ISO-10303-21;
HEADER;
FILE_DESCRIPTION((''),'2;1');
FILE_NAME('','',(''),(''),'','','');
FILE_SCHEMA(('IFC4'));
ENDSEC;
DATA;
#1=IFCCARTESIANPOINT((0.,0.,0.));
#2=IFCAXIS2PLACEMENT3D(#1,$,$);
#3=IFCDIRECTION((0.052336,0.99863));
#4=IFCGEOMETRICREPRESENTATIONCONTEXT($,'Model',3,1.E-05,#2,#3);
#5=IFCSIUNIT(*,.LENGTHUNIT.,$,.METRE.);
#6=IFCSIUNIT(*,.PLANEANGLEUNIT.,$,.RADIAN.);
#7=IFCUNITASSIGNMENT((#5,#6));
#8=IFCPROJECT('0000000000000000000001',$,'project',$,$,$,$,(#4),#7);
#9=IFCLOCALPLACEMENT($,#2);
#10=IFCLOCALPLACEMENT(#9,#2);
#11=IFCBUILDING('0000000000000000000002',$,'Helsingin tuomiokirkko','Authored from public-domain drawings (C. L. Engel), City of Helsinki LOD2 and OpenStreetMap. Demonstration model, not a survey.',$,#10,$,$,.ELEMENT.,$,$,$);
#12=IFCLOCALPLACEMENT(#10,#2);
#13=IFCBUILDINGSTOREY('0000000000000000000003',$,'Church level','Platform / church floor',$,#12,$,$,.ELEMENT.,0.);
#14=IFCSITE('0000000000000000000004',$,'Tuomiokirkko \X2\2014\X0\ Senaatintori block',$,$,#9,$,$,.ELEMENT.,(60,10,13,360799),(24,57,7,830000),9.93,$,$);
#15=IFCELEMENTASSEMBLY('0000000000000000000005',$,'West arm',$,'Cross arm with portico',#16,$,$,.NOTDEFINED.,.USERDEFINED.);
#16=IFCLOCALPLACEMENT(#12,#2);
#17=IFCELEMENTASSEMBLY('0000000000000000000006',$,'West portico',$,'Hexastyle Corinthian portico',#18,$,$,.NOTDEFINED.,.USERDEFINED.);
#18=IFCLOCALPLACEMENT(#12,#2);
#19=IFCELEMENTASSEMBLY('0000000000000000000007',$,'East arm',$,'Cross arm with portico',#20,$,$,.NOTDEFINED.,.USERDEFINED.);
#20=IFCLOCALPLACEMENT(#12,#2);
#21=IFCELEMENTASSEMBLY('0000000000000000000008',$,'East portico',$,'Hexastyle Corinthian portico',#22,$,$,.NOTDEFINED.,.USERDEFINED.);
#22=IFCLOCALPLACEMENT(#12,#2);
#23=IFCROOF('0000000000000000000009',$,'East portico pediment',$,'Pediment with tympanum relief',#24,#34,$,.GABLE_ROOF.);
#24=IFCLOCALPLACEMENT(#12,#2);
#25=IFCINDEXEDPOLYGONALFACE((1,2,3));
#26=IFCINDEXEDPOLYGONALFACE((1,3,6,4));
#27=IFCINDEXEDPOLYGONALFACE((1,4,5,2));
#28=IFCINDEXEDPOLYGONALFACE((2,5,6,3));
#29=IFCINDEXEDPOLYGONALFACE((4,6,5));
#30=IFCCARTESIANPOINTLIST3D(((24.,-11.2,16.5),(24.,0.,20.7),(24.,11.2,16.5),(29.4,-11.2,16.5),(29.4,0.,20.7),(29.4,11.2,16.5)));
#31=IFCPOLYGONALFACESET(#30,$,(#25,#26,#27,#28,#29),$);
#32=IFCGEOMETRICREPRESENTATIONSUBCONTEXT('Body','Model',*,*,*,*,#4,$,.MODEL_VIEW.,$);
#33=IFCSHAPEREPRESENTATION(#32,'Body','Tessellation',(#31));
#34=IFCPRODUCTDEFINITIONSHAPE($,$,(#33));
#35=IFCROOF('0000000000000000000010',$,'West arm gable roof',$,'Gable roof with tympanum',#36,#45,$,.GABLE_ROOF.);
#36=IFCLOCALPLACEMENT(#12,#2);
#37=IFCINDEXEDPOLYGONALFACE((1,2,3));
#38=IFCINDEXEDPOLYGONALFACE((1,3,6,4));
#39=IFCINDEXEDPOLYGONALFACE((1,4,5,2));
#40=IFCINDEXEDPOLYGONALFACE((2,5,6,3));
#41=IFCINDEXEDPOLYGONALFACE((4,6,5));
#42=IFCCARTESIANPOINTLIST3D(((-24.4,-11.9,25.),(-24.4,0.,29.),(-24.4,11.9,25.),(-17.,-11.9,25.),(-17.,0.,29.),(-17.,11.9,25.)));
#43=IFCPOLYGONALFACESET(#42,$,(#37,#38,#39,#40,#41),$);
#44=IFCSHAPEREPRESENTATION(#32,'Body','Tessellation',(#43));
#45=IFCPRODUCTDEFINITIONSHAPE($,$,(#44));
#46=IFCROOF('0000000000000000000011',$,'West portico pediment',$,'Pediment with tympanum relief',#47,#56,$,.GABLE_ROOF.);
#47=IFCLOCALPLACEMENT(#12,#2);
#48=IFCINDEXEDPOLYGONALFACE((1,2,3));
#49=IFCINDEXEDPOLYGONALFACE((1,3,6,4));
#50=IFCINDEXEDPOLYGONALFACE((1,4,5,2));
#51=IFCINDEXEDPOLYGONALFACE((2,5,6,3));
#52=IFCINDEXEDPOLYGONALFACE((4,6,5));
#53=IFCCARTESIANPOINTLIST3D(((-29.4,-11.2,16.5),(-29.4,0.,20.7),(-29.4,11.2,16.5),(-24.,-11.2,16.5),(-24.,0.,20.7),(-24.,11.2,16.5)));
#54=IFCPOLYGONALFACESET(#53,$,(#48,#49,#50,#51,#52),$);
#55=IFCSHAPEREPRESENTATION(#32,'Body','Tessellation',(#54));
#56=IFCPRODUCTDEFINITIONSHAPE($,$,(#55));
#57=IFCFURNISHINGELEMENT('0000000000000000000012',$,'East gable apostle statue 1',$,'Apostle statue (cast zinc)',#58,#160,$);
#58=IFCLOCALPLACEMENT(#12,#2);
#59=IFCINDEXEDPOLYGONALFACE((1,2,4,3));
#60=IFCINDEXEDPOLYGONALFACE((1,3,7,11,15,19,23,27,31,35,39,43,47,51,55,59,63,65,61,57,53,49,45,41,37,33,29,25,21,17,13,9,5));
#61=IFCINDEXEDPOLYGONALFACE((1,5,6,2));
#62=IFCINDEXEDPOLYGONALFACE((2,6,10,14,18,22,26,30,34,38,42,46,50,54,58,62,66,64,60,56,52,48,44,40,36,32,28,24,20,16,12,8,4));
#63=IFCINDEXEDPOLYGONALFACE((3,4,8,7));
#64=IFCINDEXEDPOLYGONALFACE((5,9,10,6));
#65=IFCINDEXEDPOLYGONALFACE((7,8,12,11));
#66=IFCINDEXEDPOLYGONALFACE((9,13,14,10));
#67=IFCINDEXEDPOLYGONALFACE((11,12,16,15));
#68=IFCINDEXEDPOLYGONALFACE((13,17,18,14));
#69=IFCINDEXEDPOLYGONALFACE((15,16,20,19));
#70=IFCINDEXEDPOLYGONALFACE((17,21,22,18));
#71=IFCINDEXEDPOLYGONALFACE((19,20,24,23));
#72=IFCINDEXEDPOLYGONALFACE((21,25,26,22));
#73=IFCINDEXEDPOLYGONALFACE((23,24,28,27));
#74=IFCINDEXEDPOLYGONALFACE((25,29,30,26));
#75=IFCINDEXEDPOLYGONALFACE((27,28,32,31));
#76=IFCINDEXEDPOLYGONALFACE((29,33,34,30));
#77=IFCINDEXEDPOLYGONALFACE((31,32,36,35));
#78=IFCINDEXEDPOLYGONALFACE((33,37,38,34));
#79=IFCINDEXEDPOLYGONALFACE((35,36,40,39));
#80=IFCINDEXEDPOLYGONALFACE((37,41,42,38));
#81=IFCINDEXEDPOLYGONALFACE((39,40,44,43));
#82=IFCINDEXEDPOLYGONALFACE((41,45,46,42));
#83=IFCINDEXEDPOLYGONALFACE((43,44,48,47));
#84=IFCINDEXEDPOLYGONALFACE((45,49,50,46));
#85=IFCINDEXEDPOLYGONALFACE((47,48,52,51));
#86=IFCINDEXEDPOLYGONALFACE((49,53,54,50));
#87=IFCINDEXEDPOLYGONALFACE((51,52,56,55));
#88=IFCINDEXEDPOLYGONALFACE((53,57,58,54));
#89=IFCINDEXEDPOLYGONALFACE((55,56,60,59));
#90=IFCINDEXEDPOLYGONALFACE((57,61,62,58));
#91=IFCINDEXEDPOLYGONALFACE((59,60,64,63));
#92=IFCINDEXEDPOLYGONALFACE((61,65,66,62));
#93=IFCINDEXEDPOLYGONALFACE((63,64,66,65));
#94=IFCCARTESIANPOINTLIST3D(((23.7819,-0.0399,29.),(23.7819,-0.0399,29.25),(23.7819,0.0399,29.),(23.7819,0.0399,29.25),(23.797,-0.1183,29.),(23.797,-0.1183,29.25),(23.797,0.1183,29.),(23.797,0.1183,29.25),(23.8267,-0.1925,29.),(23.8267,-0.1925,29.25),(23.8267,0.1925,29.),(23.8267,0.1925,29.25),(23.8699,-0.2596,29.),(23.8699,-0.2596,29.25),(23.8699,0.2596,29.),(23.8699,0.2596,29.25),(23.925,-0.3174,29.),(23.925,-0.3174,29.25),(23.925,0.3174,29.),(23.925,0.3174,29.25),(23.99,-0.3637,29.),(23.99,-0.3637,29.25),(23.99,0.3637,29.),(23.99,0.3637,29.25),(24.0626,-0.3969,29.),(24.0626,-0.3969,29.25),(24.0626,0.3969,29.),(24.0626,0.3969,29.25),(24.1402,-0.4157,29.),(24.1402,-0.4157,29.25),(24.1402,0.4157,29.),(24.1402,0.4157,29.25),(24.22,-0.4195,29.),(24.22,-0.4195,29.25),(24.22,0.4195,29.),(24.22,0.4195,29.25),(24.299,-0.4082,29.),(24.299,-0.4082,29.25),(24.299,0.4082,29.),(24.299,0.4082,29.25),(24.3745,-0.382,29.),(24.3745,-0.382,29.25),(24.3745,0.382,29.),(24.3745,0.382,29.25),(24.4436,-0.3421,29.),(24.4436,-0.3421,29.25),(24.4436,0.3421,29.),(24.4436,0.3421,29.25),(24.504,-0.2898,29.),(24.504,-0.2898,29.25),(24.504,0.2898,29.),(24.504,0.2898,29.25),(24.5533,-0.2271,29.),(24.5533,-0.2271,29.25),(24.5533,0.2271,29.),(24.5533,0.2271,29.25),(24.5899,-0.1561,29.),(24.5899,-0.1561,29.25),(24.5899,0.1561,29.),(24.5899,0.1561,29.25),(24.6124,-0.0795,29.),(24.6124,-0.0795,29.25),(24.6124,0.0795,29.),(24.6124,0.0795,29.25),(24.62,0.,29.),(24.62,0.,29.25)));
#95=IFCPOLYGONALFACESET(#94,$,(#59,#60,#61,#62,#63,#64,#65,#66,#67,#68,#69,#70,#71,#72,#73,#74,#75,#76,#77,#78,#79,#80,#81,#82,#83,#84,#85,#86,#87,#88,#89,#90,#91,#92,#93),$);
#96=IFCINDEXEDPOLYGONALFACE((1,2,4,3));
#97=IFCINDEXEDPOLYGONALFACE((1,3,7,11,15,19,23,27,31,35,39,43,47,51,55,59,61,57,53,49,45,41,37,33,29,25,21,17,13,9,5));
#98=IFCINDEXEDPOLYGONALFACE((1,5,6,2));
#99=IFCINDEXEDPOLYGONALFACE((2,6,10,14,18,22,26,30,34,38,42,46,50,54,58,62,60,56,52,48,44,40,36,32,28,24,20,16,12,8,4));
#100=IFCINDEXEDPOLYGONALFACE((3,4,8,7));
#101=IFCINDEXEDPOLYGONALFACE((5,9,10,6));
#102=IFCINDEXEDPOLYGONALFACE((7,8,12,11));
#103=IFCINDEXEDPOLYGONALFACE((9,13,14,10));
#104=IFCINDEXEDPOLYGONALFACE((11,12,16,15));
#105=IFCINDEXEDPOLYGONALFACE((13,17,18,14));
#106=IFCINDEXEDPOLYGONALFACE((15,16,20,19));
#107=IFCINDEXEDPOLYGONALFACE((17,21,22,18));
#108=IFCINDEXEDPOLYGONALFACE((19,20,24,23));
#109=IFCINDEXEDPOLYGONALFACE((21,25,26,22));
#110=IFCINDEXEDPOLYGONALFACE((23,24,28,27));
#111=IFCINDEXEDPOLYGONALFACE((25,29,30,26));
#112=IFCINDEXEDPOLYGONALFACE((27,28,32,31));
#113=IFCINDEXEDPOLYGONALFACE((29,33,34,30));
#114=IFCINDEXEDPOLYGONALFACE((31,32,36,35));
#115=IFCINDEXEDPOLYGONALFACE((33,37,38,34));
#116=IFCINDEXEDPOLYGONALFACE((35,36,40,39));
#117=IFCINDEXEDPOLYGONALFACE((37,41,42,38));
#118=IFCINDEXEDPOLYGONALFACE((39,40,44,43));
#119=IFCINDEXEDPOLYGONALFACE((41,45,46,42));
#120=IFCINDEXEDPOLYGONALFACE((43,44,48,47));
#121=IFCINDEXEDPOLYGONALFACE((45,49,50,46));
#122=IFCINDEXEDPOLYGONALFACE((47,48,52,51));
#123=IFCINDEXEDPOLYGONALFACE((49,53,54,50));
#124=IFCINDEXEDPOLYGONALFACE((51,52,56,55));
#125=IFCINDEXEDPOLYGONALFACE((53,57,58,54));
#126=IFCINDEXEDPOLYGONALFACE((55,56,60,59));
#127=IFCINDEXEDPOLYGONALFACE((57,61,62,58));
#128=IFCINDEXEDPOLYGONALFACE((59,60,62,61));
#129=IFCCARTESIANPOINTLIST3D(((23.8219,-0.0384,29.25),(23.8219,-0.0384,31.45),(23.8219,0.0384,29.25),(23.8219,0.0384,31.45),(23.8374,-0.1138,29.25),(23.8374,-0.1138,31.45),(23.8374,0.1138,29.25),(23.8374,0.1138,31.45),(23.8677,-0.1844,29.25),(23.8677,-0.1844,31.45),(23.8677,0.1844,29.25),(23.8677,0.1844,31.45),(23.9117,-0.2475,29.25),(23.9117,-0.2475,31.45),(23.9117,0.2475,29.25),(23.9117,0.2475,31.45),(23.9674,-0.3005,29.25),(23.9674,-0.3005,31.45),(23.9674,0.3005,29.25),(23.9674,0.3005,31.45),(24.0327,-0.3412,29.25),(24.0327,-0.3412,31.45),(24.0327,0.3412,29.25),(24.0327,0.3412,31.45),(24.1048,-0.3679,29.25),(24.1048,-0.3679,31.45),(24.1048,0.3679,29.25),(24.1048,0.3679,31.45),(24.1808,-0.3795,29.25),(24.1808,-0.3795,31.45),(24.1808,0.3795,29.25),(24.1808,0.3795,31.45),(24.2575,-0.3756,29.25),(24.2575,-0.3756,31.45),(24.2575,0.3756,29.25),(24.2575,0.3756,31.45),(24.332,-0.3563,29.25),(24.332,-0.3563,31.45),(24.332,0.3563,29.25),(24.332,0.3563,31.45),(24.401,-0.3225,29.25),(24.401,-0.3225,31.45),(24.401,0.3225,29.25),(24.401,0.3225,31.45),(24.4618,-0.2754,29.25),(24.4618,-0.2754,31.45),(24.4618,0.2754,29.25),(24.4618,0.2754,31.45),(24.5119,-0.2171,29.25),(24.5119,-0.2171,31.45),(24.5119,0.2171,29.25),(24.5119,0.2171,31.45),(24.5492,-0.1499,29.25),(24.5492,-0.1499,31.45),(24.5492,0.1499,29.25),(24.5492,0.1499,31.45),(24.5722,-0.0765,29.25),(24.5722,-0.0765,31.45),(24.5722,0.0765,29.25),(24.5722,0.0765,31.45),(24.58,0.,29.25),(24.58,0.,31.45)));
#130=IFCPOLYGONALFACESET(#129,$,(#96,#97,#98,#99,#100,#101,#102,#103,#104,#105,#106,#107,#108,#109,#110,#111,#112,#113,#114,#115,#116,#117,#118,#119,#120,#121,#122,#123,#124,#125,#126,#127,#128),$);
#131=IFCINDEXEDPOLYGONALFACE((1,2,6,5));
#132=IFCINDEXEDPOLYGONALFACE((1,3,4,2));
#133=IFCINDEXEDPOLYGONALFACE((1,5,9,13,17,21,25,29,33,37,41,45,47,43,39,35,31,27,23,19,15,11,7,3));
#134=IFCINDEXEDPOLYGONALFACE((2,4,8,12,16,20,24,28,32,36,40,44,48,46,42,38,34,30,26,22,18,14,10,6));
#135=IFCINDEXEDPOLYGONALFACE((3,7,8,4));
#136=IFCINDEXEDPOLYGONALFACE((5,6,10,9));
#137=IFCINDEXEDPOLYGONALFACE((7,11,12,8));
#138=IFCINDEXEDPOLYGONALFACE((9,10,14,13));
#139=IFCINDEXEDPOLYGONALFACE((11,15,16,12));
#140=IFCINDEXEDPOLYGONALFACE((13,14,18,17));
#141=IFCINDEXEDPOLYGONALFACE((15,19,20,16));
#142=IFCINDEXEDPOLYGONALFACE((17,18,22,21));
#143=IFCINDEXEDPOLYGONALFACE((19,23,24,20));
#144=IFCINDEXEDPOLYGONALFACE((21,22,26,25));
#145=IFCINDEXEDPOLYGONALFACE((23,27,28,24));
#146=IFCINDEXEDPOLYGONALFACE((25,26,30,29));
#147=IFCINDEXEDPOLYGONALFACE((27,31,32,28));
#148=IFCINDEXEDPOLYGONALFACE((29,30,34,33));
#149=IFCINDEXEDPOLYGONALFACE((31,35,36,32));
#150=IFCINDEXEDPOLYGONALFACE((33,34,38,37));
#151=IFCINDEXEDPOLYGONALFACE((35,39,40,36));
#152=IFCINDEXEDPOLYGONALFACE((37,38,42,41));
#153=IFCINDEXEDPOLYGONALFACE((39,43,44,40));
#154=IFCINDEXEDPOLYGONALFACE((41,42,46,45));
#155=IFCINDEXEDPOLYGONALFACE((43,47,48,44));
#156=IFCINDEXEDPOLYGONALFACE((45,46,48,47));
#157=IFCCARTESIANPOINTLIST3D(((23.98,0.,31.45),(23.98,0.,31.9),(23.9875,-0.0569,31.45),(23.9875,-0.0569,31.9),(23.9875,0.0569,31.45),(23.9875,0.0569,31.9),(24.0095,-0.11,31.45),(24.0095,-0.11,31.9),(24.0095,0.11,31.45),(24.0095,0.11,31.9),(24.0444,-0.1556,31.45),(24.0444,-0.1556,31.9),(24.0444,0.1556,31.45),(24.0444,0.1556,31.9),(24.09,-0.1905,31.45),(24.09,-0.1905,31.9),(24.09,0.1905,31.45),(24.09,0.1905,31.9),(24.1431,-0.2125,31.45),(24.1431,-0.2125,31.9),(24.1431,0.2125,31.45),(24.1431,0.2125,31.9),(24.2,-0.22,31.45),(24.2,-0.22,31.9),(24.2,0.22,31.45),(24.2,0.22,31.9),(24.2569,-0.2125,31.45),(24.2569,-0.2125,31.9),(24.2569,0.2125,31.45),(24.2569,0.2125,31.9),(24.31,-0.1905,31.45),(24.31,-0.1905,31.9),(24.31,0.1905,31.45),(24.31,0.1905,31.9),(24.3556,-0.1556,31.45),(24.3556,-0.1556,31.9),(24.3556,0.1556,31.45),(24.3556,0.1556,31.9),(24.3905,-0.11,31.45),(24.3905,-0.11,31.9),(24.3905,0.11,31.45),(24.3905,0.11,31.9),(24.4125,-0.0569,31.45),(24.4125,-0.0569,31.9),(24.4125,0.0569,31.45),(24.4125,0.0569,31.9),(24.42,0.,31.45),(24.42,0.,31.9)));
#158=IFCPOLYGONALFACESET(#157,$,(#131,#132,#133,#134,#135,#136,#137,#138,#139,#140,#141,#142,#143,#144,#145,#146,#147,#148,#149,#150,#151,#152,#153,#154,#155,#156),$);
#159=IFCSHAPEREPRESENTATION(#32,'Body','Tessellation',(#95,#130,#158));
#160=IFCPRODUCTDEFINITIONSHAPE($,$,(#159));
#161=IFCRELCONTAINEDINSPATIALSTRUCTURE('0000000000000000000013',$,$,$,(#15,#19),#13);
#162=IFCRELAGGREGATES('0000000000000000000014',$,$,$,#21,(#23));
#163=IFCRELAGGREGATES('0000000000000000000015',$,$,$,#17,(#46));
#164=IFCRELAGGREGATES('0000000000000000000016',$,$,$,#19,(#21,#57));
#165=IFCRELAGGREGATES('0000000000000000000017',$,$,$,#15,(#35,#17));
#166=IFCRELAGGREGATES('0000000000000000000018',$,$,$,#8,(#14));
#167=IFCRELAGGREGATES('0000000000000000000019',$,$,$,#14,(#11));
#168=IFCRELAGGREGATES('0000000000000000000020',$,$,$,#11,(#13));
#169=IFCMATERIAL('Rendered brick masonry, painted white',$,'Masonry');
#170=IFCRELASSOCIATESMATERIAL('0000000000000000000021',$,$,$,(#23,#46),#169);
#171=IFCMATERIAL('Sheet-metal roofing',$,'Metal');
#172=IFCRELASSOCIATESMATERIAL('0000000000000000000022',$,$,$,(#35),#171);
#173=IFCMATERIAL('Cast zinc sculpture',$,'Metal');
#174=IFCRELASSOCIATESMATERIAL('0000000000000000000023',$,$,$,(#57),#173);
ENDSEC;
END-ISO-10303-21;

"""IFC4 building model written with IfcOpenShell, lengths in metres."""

from ifc_helpers import new_model, si_unit, direction, frame, origin, origin_2d_with_axis, place, context, subcontext, project, spatial, polyline, circle, outline, extrude, material, element, aggregate, save


model = new_model("IFC4")

# Units and contexts
model_context = context("Model", 3, precision=1e-05, world=origin(), true_north=direction((0.052336, 0.99863)))
body_context = subcontext(model_context, "Body", "Model", "MODEL_VIEW")
ifc_project = project(units=[si_unit("LENGTHUNIT", "METRE"), si_unit("PLANEANGLEUNIT", "RADIAN")], contexts=[model_context])

# Site, building, storey
site_placement = place(None, origin())
site = spatial("IfcSite", under=ifc_project, at=site_placement, Name="Tuomiokirkko — Senaatintori block", CompositionType="ELEMENT", RefLatitude=(60, 10, 13, 360799), RefLongitude=(24, 57, 7, 830000), RefElevation=9.93)
building_placement = place(site_placement, origin())
building = spatial("IfcBuilding", under=site, at=building_placement, Name="Helsingin tuomiokirkko", Description="Authored from public-domain drawings (C. L. Engel), City of Helsinki LOD2 and OpenStreetMap. Demonstration model, not a survey.", CompositionType="ELEMENT")
storey_placement = place(building_placement, origin())
storey = spatial("IfcBuildingStorey", under=building, at=storey_placement, Name="Church level", Description="Platform / church floor", CompositionType="ELEMENT", Elevation=0.0)

# Element assemblies
assembly_1_placement = place(building_placement, origin())
assembly_1 = element("IfcElementAssembly", 1, at=assembly_1_placement, inside=storey, Name="West arm", ObjectType="Cross arm with portico", AssemblyPlace="NOTDEFINED", PredefinedType="USERDEFINED")
ifc_material_1 = material(Name="Rendered brick masonry, painted white", Category="Masonry")
assembly_2_placement = place(building_placement, origin())
assembly_2 = element("IfcElementAssembly", 2, at=assembly_2_placement, Name="West portico", ObjectType="Hexastyle Corinthian portico", AssemblyPlace="NOTDEFINED", PredefinedType="USERDEFINED")

# Element assemblies, roof
assembly_3_placement = place(building_placement, origin())
assembly_3 = element("IfcElementAssembly", 3, at=assembly_3_placement, inside=storey, Name="East arm", ObjectType="Cross arm with portico", AssemblyPlace="NOTDEFINED", PredefinedType="USERDEFINED")
assembly_4_placement = place(building_placement, origin())
assembly_4 = element("IfcElementAssembly", 4, at=assembly_4_placement, Name="East portico", ObjectType="Hexastyle Corinthian portico", AssemblyPlace="NOTDEFINED", PredefinedType="USERDEFINED")
roof_1_placement = place(building_placement, origin())
roof_1 = element("IfcRoof", 5, at=roof_1_placement, material=ifc_material_1, Name="East portico pediment", ObjectType="Pediment with tympanum relief", PredefinedType="GABLE_ROOF", context=body_context, shape_type="SweptSolid", body=[
    extrude(outline(polyline([(-11.2, 0.0), (11.2, 0.0), (0.0, 4.2), (-11.2, 0.0)])), frame((24.0, 0.0, 16.5), z_axis=(1.0, 0.0, 0.0), x_axis=(0.0, 1.0, 0.0)), (0.0, 0.0, 1.0), 5.4),
])
aggregate(assembly_4, [roof_1])

# Roofs
ifc_material_2 = material(Name="Sheet-metal roofing", Category="Metal")
roof_2_placement = place(building_placement, origin())
roof_2 = element("IfcRoof", 6, at=roof_2_placement, material=ifc_material_2, Name="West arm gable roof", ObjectType="Gable roof with tympanum", PredefinedType="GABLE_ROOF", context=body_context, shape_type="SweptSolid", body=[
    extrude(outline(polyline([(-11.9, 0.0), (11.9, 0.0), (0.0, 4.0), (-11.9, 0.0)])), frame((-17.0, 0.0, 25.0), z_axis=(-1.0, 0.0, 0.0), x_axis=(0.0, -1.0, 0.0)), (0.0, 0.0, 1.0), 7.4),
])
roof_3_placement = place(building_placement, origin())
roof_3 = element("IfcRoof", 7, at=roof_3_placement, material=ifc_material_1, Name="West portico pediment", ObjectType="Pediment with tympanum relief", PredefinedType="GABLE_ROOF", context=body_context, shape_type="SweptSolid", body=[
    extrude(outline(polyline([(-11.2, 0.0), (11.2, 0.0), (0.0, 4.2), (-11.2, 0.0)])), frame((-24.0, 0.0, 16.5), z_axis=(-1.0, 0.0, 0.0), x_axis=(0.0, -1.0, 0.0)), (0.0, 0.0, 1.0), 5.4),
])
aggregate(assembly_2, [roof_3])

# Furnishing element
ifc_material_3 = material(Name="Cast zinc sculpture", Category="Metal")
furnishing_1_placement = place(building_placement, origin())
furnishing_1 = element("IfcFurnishingElement", 8, at=furnishing_1_placement, material=ifc_material_3, Name="East gable apostle statue 1", ObjectType="Apostle statue (cast zinc)", context=body_context, shape_type="SweptSolid", body=[
    extrude(circle(Radius=0.42, at=origin_2d_with_axis()), frame((24.2, 0.0, 29.0)), (0.0, 0.0, 1.0), 0.25),
    extrude(circle(Radius=0.38, at=origin_2d_with_axis()), frame((24.2, 0.0, 29.25)), (0.0, 0.0, 1.0), 2.2),
    extrude(circle(Radius=0.22, at=origin_2d_with_axis()), frame((24.2, 0.0, 31.45)), (0.0, 0.0, 1.0), 0.45),
])
aggregate(assembly_3, [assembly_4, furnishing_1])
aggregate(assembly_1, [roof_2, assembly_2])

save(model, "model.ifc")
